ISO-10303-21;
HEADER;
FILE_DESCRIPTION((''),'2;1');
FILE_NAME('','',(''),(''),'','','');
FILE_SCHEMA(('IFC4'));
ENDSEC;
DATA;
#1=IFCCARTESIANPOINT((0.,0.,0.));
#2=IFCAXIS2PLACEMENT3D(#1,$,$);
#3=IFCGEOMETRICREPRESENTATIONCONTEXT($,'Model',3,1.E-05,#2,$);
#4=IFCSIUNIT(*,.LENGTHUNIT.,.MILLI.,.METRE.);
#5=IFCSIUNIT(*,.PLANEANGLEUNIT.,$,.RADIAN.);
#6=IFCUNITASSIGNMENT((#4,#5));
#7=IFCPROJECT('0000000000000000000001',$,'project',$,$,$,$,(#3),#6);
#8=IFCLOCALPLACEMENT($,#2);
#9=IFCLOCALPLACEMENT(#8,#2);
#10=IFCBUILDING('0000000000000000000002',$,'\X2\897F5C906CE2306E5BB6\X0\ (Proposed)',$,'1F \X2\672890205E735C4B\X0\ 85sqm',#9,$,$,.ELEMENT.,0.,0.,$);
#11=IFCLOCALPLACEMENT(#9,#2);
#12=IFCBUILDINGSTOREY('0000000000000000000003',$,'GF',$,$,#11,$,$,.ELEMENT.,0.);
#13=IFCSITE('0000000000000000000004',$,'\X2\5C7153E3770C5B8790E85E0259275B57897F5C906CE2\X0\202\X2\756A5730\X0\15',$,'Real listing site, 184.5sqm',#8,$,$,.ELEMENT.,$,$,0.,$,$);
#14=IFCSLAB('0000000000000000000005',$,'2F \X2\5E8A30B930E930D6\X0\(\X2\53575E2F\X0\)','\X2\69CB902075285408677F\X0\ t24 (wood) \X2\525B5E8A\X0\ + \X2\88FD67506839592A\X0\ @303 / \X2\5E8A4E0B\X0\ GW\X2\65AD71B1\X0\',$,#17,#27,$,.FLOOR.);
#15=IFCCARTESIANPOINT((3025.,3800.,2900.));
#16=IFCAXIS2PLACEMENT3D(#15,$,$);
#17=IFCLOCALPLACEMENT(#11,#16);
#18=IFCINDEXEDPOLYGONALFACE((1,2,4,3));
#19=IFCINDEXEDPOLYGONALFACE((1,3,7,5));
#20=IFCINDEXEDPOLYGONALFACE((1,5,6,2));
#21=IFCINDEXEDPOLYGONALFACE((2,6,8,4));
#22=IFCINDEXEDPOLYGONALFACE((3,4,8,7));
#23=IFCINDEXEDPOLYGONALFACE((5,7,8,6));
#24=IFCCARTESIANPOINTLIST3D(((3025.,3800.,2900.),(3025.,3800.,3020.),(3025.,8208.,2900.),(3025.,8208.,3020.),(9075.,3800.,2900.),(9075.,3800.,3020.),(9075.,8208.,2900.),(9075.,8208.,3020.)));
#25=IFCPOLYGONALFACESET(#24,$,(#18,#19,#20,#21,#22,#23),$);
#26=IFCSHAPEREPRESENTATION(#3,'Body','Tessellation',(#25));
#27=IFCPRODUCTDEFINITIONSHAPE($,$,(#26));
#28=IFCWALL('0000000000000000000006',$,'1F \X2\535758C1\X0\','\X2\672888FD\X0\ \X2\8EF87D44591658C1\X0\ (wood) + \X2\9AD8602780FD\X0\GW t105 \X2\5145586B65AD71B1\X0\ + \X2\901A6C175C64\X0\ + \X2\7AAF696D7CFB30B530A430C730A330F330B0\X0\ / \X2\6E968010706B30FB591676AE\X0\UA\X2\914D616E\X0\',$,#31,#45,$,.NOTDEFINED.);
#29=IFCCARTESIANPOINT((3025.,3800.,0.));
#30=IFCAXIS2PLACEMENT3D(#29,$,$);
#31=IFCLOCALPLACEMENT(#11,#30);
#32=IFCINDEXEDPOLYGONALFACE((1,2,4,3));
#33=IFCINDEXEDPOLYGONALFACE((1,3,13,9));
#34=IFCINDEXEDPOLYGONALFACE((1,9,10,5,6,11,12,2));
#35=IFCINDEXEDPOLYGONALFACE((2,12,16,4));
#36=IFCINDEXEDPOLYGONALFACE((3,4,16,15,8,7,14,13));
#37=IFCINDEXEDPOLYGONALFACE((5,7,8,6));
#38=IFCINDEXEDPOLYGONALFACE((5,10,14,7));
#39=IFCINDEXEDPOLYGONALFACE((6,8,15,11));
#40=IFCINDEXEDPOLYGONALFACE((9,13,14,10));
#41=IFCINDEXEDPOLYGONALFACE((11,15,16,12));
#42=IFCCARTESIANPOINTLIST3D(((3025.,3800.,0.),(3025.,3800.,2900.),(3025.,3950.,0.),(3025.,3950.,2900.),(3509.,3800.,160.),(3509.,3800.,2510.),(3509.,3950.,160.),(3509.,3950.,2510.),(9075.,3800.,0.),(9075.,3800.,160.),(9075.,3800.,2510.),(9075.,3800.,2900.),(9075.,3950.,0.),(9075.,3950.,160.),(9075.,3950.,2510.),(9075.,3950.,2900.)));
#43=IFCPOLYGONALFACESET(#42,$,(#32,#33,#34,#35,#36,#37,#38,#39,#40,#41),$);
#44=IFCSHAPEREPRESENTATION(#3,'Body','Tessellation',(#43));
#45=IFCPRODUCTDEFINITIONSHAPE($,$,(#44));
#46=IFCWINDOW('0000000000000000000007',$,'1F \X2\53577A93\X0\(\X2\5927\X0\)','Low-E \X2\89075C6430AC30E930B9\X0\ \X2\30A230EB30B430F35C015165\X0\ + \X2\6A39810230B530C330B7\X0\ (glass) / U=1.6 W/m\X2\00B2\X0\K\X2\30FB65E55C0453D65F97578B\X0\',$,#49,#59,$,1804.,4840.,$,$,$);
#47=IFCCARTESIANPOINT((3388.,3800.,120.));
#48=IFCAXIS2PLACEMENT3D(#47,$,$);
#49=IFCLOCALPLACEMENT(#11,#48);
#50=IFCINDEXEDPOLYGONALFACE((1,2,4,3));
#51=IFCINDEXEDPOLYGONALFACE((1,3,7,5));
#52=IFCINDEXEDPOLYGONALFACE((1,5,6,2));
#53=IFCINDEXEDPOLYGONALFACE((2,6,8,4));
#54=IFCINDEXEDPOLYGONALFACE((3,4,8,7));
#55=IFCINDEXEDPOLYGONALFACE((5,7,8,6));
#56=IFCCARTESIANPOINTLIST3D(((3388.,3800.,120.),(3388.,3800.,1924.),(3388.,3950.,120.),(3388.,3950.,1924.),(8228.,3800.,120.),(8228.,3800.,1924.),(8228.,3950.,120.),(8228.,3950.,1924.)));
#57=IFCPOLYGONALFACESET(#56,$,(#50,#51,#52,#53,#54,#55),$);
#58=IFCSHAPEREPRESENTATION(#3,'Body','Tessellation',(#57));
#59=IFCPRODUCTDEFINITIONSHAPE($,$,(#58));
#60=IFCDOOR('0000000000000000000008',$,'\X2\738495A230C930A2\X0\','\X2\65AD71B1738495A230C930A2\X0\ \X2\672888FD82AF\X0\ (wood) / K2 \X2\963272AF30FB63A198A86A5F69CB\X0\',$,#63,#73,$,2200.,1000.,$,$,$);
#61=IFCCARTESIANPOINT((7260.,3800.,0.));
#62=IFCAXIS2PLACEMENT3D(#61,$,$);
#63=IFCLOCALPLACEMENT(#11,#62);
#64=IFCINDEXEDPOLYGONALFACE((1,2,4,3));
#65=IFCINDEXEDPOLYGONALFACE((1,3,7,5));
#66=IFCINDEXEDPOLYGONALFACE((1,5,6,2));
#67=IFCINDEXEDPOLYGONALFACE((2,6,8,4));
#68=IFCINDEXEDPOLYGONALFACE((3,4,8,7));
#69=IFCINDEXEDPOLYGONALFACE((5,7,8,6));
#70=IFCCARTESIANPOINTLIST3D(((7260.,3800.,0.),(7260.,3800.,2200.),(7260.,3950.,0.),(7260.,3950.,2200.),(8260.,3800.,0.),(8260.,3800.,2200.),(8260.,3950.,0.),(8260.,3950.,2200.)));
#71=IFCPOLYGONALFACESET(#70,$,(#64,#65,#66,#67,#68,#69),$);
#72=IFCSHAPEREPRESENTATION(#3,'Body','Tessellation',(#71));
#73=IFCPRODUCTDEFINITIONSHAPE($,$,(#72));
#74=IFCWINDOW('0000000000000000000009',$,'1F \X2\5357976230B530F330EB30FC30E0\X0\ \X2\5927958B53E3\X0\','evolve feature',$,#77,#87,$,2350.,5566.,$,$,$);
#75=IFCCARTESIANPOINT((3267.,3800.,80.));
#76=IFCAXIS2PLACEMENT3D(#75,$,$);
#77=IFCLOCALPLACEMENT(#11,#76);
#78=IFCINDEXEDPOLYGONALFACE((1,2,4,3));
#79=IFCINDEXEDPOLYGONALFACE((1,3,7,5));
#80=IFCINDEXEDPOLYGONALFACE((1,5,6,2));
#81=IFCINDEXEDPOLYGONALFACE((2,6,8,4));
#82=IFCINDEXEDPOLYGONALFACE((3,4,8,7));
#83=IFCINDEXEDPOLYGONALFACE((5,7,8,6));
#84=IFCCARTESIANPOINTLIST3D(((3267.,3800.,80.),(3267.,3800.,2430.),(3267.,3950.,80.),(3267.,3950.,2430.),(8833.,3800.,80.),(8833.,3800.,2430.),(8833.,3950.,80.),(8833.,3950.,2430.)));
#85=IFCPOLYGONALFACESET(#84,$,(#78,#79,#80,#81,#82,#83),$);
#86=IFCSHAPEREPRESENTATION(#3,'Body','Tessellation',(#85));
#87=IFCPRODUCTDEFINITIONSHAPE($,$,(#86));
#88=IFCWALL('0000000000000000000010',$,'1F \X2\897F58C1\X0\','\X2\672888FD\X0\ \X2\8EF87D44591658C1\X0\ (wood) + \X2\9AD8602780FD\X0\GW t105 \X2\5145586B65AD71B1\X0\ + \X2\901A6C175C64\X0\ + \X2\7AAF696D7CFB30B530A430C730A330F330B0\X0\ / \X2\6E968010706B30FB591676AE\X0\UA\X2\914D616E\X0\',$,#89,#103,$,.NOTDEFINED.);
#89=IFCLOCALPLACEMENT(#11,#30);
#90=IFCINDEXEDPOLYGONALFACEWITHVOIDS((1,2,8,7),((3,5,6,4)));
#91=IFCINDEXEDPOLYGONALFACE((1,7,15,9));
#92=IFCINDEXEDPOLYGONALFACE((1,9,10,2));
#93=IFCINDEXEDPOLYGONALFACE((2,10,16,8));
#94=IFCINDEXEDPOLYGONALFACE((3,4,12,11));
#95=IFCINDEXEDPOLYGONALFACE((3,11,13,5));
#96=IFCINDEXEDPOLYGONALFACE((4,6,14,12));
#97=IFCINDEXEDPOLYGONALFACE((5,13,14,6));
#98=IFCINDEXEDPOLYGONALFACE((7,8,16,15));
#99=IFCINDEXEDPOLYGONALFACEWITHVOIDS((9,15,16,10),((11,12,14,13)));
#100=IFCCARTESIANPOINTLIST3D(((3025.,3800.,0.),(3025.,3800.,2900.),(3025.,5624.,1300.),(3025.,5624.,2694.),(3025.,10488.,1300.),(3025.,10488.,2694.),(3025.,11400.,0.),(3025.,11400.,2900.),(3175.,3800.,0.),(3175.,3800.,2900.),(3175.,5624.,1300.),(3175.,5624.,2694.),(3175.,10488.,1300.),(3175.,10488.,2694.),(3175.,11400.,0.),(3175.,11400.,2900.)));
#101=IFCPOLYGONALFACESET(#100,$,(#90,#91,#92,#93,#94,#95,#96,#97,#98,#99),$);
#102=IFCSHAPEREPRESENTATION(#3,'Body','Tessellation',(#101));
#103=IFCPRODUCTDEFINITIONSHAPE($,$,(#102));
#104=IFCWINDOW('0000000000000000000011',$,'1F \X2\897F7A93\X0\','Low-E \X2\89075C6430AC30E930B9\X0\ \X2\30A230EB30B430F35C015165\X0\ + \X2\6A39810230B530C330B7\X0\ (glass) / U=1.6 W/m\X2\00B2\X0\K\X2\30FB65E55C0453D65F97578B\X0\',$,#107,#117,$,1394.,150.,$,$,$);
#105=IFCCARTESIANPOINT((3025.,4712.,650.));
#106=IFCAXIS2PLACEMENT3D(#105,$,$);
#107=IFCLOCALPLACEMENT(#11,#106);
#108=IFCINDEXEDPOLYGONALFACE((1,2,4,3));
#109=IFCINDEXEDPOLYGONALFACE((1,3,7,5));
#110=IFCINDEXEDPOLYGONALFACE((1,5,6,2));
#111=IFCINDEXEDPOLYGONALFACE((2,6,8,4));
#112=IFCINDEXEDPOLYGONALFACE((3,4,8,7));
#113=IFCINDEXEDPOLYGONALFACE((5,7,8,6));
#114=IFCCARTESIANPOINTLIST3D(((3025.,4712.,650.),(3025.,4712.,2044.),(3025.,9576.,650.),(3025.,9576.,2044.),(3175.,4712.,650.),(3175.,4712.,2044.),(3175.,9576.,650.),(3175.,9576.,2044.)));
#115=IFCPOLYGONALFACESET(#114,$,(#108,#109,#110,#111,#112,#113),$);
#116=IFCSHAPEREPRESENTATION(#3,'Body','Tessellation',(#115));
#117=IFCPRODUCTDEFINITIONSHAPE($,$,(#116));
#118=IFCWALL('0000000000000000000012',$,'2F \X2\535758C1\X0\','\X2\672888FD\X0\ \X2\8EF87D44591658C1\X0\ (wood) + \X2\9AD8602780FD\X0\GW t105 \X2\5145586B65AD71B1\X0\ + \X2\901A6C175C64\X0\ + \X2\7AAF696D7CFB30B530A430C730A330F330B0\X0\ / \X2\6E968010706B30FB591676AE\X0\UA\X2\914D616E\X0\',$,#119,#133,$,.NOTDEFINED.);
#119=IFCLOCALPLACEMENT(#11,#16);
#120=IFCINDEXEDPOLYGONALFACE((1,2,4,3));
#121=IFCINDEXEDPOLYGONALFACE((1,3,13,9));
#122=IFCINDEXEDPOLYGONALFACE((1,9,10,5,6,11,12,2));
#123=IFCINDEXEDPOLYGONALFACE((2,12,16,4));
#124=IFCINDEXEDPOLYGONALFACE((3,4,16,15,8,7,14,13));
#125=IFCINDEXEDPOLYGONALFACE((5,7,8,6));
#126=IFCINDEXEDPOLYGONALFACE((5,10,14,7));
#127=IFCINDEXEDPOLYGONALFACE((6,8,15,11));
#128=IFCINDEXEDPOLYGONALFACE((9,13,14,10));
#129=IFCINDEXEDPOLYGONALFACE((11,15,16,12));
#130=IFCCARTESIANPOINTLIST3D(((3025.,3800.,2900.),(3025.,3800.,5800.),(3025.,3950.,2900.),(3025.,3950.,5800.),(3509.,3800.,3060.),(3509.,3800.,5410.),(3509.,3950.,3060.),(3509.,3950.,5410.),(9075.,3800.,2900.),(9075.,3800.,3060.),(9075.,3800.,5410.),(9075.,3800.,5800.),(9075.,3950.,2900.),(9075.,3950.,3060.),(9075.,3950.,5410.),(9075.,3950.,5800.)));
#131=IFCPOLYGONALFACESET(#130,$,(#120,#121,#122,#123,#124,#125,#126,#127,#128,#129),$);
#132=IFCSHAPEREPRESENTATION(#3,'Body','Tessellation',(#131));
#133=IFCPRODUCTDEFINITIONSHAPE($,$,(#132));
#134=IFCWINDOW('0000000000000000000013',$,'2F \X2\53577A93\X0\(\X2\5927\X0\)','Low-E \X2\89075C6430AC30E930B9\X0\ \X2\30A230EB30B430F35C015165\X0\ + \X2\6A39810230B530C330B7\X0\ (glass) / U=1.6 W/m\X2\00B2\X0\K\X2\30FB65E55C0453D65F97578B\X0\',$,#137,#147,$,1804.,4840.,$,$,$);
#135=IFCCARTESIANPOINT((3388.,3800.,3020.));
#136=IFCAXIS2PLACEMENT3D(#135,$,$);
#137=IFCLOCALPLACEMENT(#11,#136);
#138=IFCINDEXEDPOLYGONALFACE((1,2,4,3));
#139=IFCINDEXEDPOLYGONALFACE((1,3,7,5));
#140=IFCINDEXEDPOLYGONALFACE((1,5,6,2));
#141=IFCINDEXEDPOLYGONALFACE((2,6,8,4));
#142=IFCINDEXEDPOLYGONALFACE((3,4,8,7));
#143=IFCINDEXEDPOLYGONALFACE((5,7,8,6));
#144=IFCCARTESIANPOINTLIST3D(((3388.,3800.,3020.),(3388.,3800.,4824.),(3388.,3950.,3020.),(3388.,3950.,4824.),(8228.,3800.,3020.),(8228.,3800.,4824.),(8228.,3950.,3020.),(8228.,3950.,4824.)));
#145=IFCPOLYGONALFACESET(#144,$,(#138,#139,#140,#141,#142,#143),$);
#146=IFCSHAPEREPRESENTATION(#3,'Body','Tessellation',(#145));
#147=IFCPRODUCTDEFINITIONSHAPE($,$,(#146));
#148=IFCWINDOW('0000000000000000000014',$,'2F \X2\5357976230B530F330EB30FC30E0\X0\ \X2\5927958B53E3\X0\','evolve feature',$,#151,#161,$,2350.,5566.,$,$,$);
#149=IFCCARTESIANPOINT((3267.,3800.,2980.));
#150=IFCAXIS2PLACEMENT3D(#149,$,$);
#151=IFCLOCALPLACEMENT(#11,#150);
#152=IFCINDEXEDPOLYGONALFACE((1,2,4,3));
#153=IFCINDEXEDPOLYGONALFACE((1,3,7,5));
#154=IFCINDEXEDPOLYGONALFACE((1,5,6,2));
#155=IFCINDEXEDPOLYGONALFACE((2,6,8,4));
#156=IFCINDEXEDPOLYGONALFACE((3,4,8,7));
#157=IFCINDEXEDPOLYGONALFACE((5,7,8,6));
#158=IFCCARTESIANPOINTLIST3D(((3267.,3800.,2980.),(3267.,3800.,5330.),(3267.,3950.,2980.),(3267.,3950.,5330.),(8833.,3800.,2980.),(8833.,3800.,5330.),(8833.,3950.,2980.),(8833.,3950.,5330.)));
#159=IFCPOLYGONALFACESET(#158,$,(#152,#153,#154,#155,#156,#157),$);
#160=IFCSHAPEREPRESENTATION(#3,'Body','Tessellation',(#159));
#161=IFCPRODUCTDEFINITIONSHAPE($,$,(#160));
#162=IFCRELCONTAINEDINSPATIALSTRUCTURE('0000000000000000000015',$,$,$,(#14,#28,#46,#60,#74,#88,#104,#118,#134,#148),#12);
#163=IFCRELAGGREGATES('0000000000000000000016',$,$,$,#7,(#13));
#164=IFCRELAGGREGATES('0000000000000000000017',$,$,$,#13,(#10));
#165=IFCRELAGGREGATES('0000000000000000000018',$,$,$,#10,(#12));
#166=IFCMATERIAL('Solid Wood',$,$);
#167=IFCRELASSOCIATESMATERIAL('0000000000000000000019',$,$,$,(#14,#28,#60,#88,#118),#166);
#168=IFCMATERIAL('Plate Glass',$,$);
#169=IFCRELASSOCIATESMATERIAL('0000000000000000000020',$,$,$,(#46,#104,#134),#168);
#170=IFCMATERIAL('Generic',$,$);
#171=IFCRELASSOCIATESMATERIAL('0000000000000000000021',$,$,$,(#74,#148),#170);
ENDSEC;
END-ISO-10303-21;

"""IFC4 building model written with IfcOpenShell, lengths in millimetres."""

from ifc_helpers import new_model, si_unit, frame, frame_2d, origin, place, context, project, spatial, rectangle, extrude, material, element, fill, save


model = new_model("IFC4")

# Units and contexts
model_context = context("Model", 3, precision=1e-05, world=origin())
ifc_project = project(units=[si_unit("LENGTHUNIT", "METRE", prefix="MILLI"), si_unit("PLANEANGLEUNIT", "RADIAN")], contexts=[model_context])

# Site, building, storey
site_placement = place(None, origin())
site = spatial("IfcSite", under=ifc_project, at=site_placement, Name="山口県宇部市大字西岐波202番地15", ObjectType="Real listing site, 184.5sqm", CompositionType="ELEMENT", RefElevation=0.0)
building_placement = place(site_placement, origin())
building = spatial("IfcBuilding", under=site, at=building_placement, Name="西岐波の家 (Proposed)", ObjectType="1F 木造平屋 85sqm", CompositionType="ELEMENT", ElevationOfRefHeight=0.0, ElevationOfTerrain=0.0)
storey_placement = place(building_placement, origin())
storey = spatial("IfcBuildingStorey", under=building, at=storey_placement, Name="GF", CompositionType="ELEMENT", Elevation=0.0)

# Slab
ifc_material_1 = material(Name="Solid Wood")
slab_1_placement = place(storey_placement, frame((3025.0, 3800.0, 2900.0)))
element("IfcSlab", 1, at=slab_1_placement, inside=storey, material=ifc_material_1, Name="2F 床スラブ(南帯)", Description="構造用合板 t24 (wood) 剛床 + 製材根太 @303 / 床下 GW断熱", PredefinedType="FLOOR", context=model_context, shape_type="SweptSolid", body=[
    extrude(rectangle(XDim=6050.0, YDim=4408.0, at=frame_2d((3025.0, 2204.0))), frame((3025.0, 3800.0, 2900.0)), (0.0, 0.0, 1.0), 120.0),
])
ifc_material_2 = material(Name="Generic")

# Wall, openings, windows, door
wall_1_placement = place(storey_placement, frame((3025.0, 3800.0, 0.0)))
wall_1 = element("IfcWall", 2, at=wall_1_placement, inside=storey, material=ifc_material_1, Name="1F 南壁", Description="木製 軸組外壁 (wood) + 高性能GW t105 充填断熱 + 通気層 + 窯業系サイディング / 準耐火・外皮UA配慮", PredefinedType="NOTDEFINED", context=model_context, shape_type="SweptSolid", body=[
    extrude(rectangle(XDim=6050.0, YDim=150.0, at=frame_2d((3025.0, 75.0))), frame((3025.0, 3800.0, 0.0)), (0.0, 0.0, 1.0), 2900.0),
])
opening_1_placement = place(storey_placement, frame((3388.0, 3800.0, 120.0)))
opening_1 = element("IfcOpeningElement", 3, at=opening_1_placement, cuts=wall_1, PredefinedType="NOTDEFINED", context=model_context, shape_type="SweptSolid", body=[
    extrude(rectangle(XDim=4840.0, YDim=150.0, at=frame_2d((2420.0, 75.0))), frame((3388.0, 3800.0, 120.0)), (0.0, 0.0, 1.0), 1804.0),
])
opening_2_placement = place(storey_placement, frame((7260.0, 3800.0, 0.0)))
opening_2 = element("IfcOpeningElement", 4, at=opening_2_placement, cuts=wall_1, PredefinedType="NOTDEFINED", context=model_context, shape_type="SweptSolid", body=[
    extrude(rectangle(XDim=1000.0, YDim=150.0, at=frame_2d((500.0, 75.0))), frame((7260.0, 3800.0, 0.0)), (0.0, 0.0, 1.0), 2200.0),
])
opening_3_placement = place(storey_placement, frame((3267.0, 3800.0, 80.0)))
opening_3 = element("IfcOpeningElement", 5, at=opening_3_placement, cuts=wall_1, PredefinedType="NOTDEFINED", context=model_context, shape_type="SweptSolid", body=[
    extrude(rectangle(XDim=5566.0, YDim=150.0, at=frame_2d((2783.0, 75.0))), frame((3267.0, 3800.0, 80.0)), (0.0, 0.0, 1.0), 2350.0),
])
ifc_material_3 = material(Name="Plate Glass")
window_1_placement = place(storey_placement, frame((3388.0, 3800.0, 120.0)))
window_1 = element("IfcWindow", 6, at=window_1_placement, inside=storey, material=ifc_material_3, Name="1F 南窓(大)", Description="Low-E 複層ガラス アルゴン封入 + 樹脂サッシ (glass) / U=1.6 W/m²K・日射取得型", OverallHeight=1804.0, OverallWidth=4840.0, context=model_context, shape_type="SweptSolid", body=[
    extrude(rectangle(XDim=4840.0, YDim=150.0, at=frame_2d((2420.0, 75.0))), frame((3388.0, 3800.0, 120.0)), (0.0, 0.0, 1.0), 1804.0),
])
fill(opening_1, window_1)
door_placement = place(storey_placement, frame((7260.0, 3800.0, 0.0)))
door = element("IfcDoor", 7, at=door_placement, inside=storey, material=ifc_material_1, Name="玄関ドア", Description="断熱玄関ドア 木製芯 (wood) / K2 防犯・採風機構", OverallHeight=2200.0, OverallWidth=1000.0, context=model_context, shape_type="SweptSolid", body=[
    extrude(rectangle(XDim=1000.0, YDim=150.0, at=frame_2d((500.0, 75.0))), frame((7260.0, 3800.0, 0.0)), (0.0, 0.0, 1.0), 2200.0),
])
fill(opening_2, door)
window_2_placement = place(storey_placement, frame((3267.0, 3800.0, 80.0)))
window_2 = element("IfcWindow", 8, at=window_2_placement, inside=storey, material=ifc_material_2, Name="1F 南面サンルーム 大開口", Description="evolve feature", OverallHeight=2350.0, OverallWidth=5566.0, context=model_context, shape_type="SweptSolid", body=[
    extrude(rectangle(XDim=5566.0, YDim=150.0, at=frame_2d((2783.0, 75.0))), frame((3267.0, 3800.0, 80.0)), (0.0, 0.0, 1.0), 2350.0),
])
fill(opening_3, window_2)

# Wall, opening, window
wall_2_placement = place(storey_placement, frame((3025.0, 3800.0, 0.0)))
wall_2 = element("IfcWall", 9, at=wall_2_placement, inside=storey, material=ifc_material_1, Name="1F 西壁", Description="木製 軸組外壁 (wood) + 高性能GW t105 充填断熱 + 通気層 + 窯業系サイディング / 準耐火・外皮UA配慮", PredefinedType="NOTDEFINED", context=model_context, shape_type="SweptSolid", body=[
    extrude(rectangle(XDim=150.0, YDim=7600.0, at=frame_2d((75.0, 3800.0))), frame((3025.0, 3800.0, 0.0)), (0.0, 0.0, 1.0), 2900.0),
])
opening_4_placement = place(storey_placement, frame((3025.0, 4712.0, 650.0)))
opening_4 = element("IfcOpeningElement", 10, at=opening_4_placement, cuts=wall_2, PredefinedType="NOTDEFINED", context=model_context, shape_type="SweptSolid", body=[
    extrude(rectangle(XDim=150.0, YDim=4864.0, at=frame_2d((75.0, 2432.0))), frame((3025.0, 4712.0, 650.0)), (0.0, 0.0, 1.0), 1394.0),
])
window_3_placement = place(storey_placement, frame((3025.0, 4712.0, 650.0)))
window_3 = element("IfcWindow", 11, at=window_3_placement, inside=storey, material=ifc_material_3, Name="1F 西窓", Description="Low-E 複層ガラス アルゴン封入 + 樹脂サッシ (glass) / U=1.6 W/m²K・日射取得型", OverallHeight=1394.0, OverallWidth=150.0, context=model_context, shape_type="SweptSolid", body=[
    extrude(rectangle(XDim=150.0, YDim=4864.0, at=frame_2d((75.0, 2432.0))), frame((3025.0, 4712.0, 650.0)), (0.0, 0.0, 1.0), 1394.0),
])
fill(opening_4, window_3)

# Wall, openings, windows
wall_3_placement = place(storey_placement, frame((3025.0, 3800.0, 2900.0)))
wall_3 = element("IfcWall", 12, at=wall_3_placement, inside=storey, material=ifc_material_1, Name="2F 南壁", Description="木製 軸組外壁 (wood) + 高性能GW t105 充填断熱 + 通気層 + 窯業系サイディング / 準耐火・外皮UA配慮", PredefinedType="NOTDEFINED", context=model_context, shape_type="SweptSolid", body=[
    extrude(rectangle(XDim=6050.0, YDim=150.0, at=frame_2d((3025.0, 75.0))), frame((3025.0, 3800.0, 2900.0)), (0.0, 0.0, 1.0), 2900.0),
])
opening_5_placement = place(storey_placement, frame((3388.0, 3800.0, 3020.0)))
opening_5 = element("IfcOpeningElement", 13, at=opening_5_placement, cuts=wall_3, PredefinedType="NOTDEFINED", context=model_context, shape_type="SweptSolid", body=[
    extrude(rectangle(XDim=4840.0, YDim=150.0, at=frame_2d((2420.0, 75.0))), frame((3388.0, 3800.0, 3020.0)), (0.0, 0.0, 1.0), 1804.0),
])
opening_6_placement = place(storey_placement, frame((3267.0, 3800.0, 2980.0)))
opening_6 = element("IfcOpeningElement", 14, at=opening_6_placement, cuts=wall_3, PredefinedType="NOTDEFINED", context=model_context, shape_type="SweptSolid", body=[
    extrude(rectangle(XDim=5566.0, YDim=150.0, at=frame_2d((2783.0, 75.0))), frame((3267.0, 3800.0, 2980.0)), (0.0, 0.0, 1.0), 2350.0),
])
window_4_placement = place(storey_placement, frame((3388.0, 3800.0, 3020.0)))
window_4 = element("IfcWindow", 15, at=window_4_placement, inside=storey, material=ifc_material_3, Name="2F 南窓(大)", Description="Low-E 複層ガラス アルゴン封入 + 樹脂サッシ (glass) / U=1.6 W/m²K・日射取得型", OverallHeight=1804.0, OverallWidth=4840.0, context=model_context, shape_type="SweptSolid", body=[
    extrude(rectangle(XDim=4840.0, YDim=150.0, at=frame_2d((2420.0, 75.0))), frame((3388.0, 3800.0, 3020.0)), (0.0, 0.0, 1.0), 1804.0),
])
fill(opening_5, window_4)
window_5_placement = place(storey_placement, frame((3267.0, 3800.0, 2980.0)))
window_5 = element("IfcWindow", 16, at=window_5_placement, inside=storey, material=ifc_material_2, Name="2F 南面サンルーム 大開口", Description="evolve feature", OverallHeight=2350.0, OverallWidth=5566.0, context=model_context, shape_type="SweptSolid", body=[
    extrude(rectangle(XDim=5566.0, YDim=150.0, at=frame_2d((2783.0, 75.0))), frame((3267.0, 3800.0, 2980.0)), (0.0, 0.0, 1.0), 2350.0),
])
fill(opening_6, window_5)

save(model, "model.ifc")
